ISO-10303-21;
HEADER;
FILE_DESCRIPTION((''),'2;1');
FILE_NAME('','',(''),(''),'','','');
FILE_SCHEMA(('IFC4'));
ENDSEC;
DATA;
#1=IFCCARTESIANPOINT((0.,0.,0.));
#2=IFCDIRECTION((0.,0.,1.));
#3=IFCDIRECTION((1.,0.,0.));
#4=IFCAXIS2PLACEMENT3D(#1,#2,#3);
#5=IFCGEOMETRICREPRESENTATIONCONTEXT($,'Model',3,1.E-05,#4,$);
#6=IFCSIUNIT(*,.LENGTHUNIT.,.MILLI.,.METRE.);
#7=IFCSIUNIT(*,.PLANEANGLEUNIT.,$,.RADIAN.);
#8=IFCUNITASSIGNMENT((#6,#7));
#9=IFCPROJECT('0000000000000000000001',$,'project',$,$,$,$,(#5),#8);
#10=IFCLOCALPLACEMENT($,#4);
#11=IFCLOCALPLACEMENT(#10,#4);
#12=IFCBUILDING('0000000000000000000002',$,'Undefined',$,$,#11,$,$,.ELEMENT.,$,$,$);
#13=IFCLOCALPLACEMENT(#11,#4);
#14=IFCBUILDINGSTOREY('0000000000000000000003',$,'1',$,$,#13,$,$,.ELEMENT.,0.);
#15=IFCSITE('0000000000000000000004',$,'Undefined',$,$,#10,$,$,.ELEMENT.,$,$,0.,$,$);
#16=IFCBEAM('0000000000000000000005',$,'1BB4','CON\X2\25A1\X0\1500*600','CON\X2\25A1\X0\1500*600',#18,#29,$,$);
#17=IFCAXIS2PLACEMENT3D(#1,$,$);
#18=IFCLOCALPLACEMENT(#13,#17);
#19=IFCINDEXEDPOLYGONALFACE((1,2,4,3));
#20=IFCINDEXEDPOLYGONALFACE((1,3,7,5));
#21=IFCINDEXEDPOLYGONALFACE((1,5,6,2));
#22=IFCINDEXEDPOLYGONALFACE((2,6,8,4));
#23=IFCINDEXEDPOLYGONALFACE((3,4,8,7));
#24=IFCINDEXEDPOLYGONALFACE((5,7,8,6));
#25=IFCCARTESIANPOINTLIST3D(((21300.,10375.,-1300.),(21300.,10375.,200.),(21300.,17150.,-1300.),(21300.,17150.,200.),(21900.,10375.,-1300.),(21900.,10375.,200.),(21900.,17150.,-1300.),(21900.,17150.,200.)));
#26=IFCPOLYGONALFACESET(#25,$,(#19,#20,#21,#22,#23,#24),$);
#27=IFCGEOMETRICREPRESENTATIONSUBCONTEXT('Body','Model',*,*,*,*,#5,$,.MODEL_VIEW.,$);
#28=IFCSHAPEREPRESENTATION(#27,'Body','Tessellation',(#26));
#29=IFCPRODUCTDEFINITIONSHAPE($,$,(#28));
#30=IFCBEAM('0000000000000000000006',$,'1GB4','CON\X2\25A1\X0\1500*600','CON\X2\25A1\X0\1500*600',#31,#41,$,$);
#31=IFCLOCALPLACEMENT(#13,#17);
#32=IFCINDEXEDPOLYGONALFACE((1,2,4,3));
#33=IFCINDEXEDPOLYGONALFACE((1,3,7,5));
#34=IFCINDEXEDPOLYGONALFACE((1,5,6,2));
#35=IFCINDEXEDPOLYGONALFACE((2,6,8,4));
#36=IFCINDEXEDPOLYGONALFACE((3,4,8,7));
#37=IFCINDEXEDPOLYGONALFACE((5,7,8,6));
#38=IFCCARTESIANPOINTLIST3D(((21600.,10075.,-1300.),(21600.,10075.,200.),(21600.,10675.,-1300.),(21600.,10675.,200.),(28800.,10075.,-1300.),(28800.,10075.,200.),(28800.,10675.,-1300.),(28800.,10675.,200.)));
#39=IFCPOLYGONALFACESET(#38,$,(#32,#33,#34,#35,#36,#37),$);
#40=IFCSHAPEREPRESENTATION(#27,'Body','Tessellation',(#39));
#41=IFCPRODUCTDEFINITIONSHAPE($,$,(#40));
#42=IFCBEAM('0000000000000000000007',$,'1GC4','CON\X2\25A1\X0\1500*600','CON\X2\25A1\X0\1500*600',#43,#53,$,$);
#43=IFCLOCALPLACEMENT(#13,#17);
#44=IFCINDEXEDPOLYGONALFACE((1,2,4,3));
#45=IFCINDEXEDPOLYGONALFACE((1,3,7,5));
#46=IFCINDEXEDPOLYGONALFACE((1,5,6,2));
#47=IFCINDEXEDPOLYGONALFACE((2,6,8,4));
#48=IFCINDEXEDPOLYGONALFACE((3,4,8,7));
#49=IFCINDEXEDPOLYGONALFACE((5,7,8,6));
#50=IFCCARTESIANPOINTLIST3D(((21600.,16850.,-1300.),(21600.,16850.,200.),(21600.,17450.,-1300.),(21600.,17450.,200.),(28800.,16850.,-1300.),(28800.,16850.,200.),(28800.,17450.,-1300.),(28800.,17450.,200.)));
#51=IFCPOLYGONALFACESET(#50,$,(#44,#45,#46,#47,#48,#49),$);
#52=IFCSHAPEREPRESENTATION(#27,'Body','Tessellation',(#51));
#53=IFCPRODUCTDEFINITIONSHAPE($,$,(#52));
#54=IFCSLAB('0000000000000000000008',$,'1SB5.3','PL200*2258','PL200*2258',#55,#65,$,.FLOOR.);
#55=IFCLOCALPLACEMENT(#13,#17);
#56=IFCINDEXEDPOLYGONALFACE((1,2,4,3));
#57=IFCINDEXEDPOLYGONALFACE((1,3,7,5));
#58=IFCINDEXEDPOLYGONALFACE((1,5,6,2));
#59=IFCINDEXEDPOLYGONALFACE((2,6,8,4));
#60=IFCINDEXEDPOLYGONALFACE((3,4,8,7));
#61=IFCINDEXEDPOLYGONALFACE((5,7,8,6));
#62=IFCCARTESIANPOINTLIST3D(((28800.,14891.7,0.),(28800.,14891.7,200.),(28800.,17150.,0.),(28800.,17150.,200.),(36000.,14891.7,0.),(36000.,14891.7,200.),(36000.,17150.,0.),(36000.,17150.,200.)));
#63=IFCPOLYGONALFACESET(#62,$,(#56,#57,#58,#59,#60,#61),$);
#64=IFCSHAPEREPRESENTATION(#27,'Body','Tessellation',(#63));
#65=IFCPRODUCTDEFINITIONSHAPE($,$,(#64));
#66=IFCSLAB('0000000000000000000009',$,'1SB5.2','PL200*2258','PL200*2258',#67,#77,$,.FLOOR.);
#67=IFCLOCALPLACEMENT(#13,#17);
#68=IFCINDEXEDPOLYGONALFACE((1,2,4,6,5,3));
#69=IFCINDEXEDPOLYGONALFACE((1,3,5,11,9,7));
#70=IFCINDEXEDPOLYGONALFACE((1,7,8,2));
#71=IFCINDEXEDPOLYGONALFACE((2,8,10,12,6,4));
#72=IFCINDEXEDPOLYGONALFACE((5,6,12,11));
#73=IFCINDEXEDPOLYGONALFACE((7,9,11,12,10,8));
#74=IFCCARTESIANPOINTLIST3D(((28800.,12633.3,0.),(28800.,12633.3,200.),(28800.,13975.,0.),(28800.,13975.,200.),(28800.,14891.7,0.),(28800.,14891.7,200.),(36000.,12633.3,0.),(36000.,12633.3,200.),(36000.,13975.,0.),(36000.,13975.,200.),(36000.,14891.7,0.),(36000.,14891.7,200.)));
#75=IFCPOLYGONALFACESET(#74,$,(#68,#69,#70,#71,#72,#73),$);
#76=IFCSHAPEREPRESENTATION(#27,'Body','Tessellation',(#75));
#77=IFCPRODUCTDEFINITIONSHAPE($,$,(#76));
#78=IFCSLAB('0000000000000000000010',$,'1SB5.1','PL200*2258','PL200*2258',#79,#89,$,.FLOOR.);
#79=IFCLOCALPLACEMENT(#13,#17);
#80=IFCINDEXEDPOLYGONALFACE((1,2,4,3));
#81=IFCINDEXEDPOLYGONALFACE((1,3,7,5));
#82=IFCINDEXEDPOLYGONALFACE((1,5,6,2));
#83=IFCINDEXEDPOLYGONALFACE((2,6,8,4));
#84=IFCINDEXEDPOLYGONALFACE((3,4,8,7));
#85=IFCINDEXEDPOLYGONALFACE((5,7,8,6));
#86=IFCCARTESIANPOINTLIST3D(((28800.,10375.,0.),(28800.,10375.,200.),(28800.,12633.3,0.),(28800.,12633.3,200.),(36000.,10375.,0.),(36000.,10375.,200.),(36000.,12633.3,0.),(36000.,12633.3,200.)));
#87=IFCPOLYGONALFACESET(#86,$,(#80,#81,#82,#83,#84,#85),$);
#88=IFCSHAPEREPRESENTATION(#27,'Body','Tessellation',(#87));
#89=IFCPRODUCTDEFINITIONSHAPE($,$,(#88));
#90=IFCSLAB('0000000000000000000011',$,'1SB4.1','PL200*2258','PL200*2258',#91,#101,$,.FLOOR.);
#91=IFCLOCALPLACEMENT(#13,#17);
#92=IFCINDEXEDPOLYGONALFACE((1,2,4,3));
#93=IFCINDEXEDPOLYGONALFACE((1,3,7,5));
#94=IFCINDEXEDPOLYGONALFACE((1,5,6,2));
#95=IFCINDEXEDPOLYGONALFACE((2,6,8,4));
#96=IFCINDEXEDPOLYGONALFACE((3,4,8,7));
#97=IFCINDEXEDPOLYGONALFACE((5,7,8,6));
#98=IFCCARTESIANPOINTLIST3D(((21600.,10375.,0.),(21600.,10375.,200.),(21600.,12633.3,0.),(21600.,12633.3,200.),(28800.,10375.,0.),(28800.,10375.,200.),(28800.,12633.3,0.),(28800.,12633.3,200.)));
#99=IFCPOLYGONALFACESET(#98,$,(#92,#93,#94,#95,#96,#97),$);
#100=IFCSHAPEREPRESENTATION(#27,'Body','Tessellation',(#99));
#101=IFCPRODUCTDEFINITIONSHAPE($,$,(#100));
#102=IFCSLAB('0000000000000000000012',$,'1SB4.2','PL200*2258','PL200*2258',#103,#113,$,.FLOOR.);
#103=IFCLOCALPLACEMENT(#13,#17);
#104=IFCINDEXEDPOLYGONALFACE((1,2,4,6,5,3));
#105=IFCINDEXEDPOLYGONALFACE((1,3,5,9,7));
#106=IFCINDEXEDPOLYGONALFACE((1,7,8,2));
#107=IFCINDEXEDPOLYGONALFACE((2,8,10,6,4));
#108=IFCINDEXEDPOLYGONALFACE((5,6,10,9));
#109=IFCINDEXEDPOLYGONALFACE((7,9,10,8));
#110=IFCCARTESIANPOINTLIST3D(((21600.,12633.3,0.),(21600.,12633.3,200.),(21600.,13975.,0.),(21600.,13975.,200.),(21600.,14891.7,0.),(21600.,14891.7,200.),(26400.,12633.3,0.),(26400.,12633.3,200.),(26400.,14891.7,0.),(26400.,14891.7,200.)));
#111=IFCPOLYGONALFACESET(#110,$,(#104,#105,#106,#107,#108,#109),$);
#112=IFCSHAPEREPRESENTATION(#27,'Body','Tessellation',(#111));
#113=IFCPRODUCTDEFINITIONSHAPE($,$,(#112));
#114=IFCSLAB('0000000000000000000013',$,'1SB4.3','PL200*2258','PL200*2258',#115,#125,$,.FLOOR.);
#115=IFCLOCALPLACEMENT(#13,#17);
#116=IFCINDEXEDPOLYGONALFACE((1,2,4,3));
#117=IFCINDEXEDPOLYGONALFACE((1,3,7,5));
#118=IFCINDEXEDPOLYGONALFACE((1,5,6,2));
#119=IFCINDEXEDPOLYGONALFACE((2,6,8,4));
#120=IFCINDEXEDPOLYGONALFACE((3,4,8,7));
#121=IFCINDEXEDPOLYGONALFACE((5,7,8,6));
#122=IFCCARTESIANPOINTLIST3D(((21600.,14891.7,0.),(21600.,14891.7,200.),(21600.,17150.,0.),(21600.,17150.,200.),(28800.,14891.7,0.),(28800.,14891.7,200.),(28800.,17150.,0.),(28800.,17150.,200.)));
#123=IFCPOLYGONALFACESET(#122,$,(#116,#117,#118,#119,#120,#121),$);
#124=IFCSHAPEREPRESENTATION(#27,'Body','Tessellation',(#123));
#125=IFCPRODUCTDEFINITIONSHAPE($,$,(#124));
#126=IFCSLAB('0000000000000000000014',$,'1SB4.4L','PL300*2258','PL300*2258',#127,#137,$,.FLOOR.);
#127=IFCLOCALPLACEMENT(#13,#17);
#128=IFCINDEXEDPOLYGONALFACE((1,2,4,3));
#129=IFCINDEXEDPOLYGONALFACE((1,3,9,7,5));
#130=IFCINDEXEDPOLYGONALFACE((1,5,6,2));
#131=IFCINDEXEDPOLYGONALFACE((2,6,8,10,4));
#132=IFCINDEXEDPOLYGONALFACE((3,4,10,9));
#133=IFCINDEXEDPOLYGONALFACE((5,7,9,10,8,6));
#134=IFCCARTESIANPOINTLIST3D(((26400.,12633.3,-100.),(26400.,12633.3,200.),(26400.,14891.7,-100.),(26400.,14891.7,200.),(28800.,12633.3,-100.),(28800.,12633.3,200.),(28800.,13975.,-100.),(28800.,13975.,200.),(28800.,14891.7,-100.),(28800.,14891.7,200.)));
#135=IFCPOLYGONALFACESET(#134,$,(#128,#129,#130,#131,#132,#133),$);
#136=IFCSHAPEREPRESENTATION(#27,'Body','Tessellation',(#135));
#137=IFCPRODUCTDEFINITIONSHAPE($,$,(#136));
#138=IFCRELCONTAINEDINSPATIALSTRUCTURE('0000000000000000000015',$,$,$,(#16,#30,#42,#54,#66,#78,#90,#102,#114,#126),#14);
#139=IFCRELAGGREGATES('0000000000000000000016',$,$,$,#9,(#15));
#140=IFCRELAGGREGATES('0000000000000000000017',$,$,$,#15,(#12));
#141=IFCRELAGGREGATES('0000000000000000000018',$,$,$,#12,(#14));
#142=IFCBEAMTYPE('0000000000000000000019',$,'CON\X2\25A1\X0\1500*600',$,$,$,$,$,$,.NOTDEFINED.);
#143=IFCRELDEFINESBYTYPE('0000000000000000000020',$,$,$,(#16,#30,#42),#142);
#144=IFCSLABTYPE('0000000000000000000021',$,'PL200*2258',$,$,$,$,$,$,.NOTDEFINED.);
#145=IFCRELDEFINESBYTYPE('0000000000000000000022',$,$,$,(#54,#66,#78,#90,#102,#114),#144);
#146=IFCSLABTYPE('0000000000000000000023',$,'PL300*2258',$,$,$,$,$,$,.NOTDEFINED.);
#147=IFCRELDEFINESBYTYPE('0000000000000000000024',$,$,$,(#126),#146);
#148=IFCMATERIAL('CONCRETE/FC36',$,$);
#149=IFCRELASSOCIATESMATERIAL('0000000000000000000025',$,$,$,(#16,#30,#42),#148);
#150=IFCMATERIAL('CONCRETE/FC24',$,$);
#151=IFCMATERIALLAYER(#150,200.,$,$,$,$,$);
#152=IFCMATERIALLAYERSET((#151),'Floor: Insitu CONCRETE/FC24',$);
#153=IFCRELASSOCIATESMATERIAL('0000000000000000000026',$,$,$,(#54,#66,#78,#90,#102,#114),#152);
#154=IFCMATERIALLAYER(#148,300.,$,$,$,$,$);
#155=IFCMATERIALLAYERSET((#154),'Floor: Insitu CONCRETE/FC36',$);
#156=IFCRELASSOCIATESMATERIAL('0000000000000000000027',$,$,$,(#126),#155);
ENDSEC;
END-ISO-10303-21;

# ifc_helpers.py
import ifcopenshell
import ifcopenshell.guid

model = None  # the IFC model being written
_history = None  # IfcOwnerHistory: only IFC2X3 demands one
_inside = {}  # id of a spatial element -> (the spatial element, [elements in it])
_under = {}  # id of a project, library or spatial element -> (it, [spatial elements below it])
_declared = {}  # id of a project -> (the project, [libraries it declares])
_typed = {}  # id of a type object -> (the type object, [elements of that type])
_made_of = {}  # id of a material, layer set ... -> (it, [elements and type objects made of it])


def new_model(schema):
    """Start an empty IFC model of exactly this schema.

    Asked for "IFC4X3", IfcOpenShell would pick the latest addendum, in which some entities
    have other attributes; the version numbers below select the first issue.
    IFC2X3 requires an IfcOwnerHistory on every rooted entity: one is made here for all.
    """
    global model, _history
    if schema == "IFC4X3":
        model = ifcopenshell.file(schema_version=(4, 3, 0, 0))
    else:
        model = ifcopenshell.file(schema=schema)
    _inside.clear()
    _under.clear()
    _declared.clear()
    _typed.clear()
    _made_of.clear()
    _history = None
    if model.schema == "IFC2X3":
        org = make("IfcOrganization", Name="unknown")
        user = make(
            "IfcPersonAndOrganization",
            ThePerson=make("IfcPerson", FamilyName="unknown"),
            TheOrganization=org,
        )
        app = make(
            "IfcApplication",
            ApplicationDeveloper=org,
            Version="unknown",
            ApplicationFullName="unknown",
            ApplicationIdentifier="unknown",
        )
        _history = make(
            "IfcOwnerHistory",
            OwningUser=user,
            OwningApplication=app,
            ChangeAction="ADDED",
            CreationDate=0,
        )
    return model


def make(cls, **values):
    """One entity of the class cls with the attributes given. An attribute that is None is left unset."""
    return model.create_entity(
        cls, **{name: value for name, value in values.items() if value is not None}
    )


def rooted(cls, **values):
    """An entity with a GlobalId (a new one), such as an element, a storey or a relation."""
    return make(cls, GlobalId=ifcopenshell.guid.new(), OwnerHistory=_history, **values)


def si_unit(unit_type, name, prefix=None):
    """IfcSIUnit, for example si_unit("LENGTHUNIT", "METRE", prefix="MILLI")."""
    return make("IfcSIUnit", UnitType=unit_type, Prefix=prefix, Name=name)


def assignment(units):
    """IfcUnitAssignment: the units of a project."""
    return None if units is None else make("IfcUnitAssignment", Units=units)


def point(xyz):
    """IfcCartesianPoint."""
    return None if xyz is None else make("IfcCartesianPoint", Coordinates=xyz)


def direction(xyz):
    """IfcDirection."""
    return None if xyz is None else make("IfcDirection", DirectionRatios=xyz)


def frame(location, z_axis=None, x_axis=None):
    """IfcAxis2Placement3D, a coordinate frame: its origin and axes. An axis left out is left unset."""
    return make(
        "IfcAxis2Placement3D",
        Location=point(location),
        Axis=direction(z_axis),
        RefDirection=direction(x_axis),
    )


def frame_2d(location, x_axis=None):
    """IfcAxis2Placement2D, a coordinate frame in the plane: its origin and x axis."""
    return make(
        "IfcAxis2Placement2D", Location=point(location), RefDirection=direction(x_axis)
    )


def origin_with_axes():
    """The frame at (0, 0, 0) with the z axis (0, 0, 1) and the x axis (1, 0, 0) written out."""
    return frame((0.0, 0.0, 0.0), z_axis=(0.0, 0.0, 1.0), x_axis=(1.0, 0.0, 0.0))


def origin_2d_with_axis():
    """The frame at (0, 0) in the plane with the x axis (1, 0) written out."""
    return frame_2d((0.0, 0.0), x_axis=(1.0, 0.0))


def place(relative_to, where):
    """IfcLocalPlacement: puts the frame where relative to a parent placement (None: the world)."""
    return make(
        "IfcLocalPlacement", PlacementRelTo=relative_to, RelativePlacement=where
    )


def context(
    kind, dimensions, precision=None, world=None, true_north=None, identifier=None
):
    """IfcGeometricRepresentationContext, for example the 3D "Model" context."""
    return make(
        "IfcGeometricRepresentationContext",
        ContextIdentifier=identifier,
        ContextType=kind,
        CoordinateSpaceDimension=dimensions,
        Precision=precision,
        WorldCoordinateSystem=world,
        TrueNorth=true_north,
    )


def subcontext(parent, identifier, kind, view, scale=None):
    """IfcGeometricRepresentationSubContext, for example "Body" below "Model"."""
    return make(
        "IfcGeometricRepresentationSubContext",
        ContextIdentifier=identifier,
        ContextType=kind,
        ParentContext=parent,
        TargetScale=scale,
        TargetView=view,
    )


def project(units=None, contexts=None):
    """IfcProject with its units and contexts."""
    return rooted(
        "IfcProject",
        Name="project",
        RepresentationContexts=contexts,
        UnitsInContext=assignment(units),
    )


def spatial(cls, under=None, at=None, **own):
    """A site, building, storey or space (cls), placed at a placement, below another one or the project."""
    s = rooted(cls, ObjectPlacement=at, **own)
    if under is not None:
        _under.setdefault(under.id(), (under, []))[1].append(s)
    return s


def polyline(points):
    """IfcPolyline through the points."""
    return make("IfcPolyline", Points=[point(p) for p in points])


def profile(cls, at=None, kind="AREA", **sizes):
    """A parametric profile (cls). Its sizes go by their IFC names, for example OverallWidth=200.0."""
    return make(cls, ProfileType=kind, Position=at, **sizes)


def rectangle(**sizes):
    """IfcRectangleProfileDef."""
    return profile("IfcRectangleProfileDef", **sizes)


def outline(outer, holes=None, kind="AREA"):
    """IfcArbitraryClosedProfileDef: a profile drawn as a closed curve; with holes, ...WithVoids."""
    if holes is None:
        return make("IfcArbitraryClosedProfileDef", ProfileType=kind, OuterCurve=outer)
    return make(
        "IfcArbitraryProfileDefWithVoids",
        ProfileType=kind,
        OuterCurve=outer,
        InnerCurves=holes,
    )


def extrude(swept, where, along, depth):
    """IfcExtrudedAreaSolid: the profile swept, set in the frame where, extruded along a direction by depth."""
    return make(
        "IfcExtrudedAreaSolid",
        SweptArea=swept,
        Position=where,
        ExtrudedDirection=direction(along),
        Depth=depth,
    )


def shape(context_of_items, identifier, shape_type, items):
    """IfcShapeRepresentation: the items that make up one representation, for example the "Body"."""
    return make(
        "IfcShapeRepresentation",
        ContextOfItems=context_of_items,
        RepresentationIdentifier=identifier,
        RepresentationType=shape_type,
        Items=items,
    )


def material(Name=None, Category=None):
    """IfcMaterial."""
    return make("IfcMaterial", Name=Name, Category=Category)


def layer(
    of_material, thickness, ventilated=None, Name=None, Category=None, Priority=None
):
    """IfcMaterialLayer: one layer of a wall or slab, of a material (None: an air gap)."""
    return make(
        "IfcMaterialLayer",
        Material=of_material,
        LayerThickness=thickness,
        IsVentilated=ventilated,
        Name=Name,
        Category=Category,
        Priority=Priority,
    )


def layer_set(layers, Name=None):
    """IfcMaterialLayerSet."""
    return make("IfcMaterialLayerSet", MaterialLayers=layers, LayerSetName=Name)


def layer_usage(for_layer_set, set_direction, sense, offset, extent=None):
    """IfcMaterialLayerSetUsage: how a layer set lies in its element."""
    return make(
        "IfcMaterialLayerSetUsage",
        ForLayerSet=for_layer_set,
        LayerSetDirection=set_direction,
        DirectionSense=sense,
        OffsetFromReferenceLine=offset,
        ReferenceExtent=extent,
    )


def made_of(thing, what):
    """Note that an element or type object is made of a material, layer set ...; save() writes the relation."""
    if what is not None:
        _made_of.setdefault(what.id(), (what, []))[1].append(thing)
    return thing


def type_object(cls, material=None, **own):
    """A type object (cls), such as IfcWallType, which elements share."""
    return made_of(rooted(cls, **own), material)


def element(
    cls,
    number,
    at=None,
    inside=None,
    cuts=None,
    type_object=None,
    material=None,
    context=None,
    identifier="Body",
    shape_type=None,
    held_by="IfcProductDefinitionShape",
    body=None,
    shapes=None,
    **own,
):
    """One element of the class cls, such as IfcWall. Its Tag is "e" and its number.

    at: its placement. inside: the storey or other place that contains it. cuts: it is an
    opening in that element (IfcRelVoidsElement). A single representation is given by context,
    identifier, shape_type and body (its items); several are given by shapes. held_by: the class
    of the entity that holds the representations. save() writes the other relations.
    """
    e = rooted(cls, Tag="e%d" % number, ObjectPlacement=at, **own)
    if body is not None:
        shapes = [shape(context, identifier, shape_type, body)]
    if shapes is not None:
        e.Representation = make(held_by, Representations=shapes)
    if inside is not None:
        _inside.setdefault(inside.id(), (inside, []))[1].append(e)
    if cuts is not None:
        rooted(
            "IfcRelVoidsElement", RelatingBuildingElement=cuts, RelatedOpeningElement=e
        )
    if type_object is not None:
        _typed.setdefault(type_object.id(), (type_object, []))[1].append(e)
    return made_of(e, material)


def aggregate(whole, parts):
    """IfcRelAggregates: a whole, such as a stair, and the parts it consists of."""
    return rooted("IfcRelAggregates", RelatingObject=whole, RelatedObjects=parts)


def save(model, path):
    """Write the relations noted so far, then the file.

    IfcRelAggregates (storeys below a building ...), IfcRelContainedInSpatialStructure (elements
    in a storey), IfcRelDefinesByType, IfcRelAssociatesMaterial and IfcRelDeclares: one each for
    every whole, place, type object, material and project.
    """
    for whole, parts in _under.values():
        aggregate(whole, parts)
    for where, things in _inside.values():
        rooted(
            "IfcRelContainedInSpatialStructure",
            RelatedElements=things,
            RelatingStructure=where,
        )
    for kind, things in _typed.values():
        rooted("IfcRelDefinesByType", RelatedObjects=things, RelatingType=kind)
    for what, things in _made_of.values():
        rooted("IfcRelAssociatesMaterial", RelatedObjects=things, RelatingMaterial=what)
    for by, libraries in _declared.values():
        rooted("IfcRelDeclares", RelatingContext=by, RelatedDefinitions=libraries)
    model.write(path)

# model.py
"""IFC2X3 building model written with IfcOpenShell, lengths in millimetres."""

from ifc_helpers import new_model, si_unit, frame, origin_with_axes, origin_2d_with_axis, place, context, subcontext, project, spatial, polyline, rectangle, outline, extrude, material, layer, layer_set, layer_usage, type_object, element, save


model = new_model("IFC2X3")

# Units and contexts
model_context = context("Model", 3, precision=1e-05, world=origin_with_axes())
body_context = subcontext(model_context, "Body", "Model", "MODEL_VIEW")
ifc_project = project(units=[si_unit("LENGTHUNIT", "METRE", prefix="MILLI"), si_unit("PLANEANGLEUNIT", "RADIAN")], contexts=[model_context])

# Site, building, storey
site_placement = place(None, origin_with_axes())
site = spatial("IfcSite", under=ifc_project, at=site_placement, Name="Undefined", CompositionType="ELEMENT", RefElevation=0.0)
building_placement = place(site_placement, origin_with_axes())
building = spatial("IfcBuilding", under=site, at=building_placement, Name="Undefined", CompositionType="ELEMENT")
storey_placement = place(building_placement, origin_with_axes())
storey = spatial("IfcBuildingStorey", under=building, at=storey_placement, Name="1", CompositionType="ELEMENT", Elevation=0.0)

# Shared definitions
ifc_material_1 = material(Name="CONCRETE/FC24")

# Beams
beam_type = type_object("IfcBeamType", Name="CON□1500*600", PredefinedType="NOTDEFINED")
ifc_material_2 = material(Name="CONCRETE/FC36")
beam_1_placement = place(storey_placement, frame((21600.0, 10375.0, -550.0), z_axis=(0.0, 0.0, 1.0), x_axis=(0.0, 1.0, 0.0)))
element("IfcBeam", 1, at=beam_1_placement, inside=storey, type_object=beam_type, material=ifc_material_2, Name="1BB4", Description="CON□1500*600", ObjectType="CON□1500*600", context=body_context, shape_type="SweptSolid", body=[
    extrude(rectangle(XDim=600.0, YDim=1500.0, at=origin_2d_with_axis()), frame((6775.0, 0.0, 0.0), z_axis=(-1.0, 0.0, 0.0), x_axis=(0.0, -1.0, 0.0)), (0.0, 0.0, 1.0), 6775.0),
])
for number, where, z_axis, x_axis, name in (
    (2, (21600.0, 10375.0, -550.0), (0.0, 0.0, 1.0), (1.0, 0.0, 0.0), "1GB4"),
    (3, (21600.0, 17150.0, -550.0), (0.0, 0.0, 1.0), (1.0, 0.0, 0.0), "1GC4"),
):
    element("IfcBeam", number, at=place(storey_placement, frame(where, z_axis=z_axis, x_axis=x_axis)), inside=storey, type_object=beam_type, material=ifc_material_2, Name=name, Description="CON□1500*600", ObjectType="CON□1500*600", context=body_context, shape_type="SweptSolid", body=[
        extrude(rectangle(XDim=600.0, YDim=1500.0, at=origin_2d_with_axis()), frame((7200.0, 0.0, 0.0), z_axis=(-1.0, 0.0, 0.0), x_axis=(0.0, -1.0, 0.0)), (0.0, 0.0, 1.0), 7200.0),
    ])

# Slabs
ifc_layer_1 = layer(ifc_material_1, 200.0)
ifc_layer_set_1 = layer_set([ifc_layer_1], Name="Floor: Insitu CONCRETE/FC24")
ifc_layer_usage_1 = layer_usage(ifc_layer_set_1, "AXIS3", "POSITIVE", -100.0)
slab_type_1 = type_object("IfcSlabType", Name="PL200*2258", PredefinedType="NOTDEFINED")
slab_1_placement = place(storey_placement, frame((28800.0, 14891.7, 100.0), z_axis=(0.0, 0.0, 1.0), x_axis=(1.0, 0.0, 0.0)))
element("IfcSlab", 4, at=slab_1_placement, inside=storey, type_object=slab_type_1, material=ifc_layer_usage_1, Name="1SB5.3", Description="PL200*2258", ObjectType="PL200*2258", PredefinedType="FLOOR", context=body_context, shape_type="SweptSolid", body=[
    extrude(outline(polyline([(0.0, 0.0), (7200.0, 0.0), (7200.0, 2258.3), (0.0, 2258.3), (0.0, 0.0)])), frame((0.0, 0.0, -100.0), z_axis=(0.0, 0.0, 1.0), x_axis=(1.0, 0.0, 0.0)), (0.0, 0.0, 1.0), 200.0),
])
ifc_layer_usage_2 = layer_usage(ifc_layer_set_1, "AXIS3", "POSITIVE", -100.0)
slab_2_placement = place(storey_placement, frame((28800.0, 12633.3, 100.0), z_axis=(0.0, 0.0, 1.0), x_axis=(1.0, 0.0, 0.0)))
element("IfcSlab", 5, at=slab_2_placement, inside=storey, type_object=slab_type_1, material=ifc_layer_usage_2, Name="1SB5.2", Description="PL200*2258", ObjectType="PL200*2258", PredefinedType="FLOOR", context=body_context, shape_type="SweptSolid", body=[
    extrude(outline(polyline([(0.0, 0.0), (7200.0, 0.0), (7200.0, 1341.7), (7200.0, 2258.4), (0.0, 2258.4), (0.0, 1341.7), (0.0, 0.0)])), frame((0.0, 0.0, -100.0), z_axis=(0.0, 0.0, 1.0), x_axis=(1.0, 0.0, 0.0)), (0.0, 0.0, 1.0), 200.0),
])
ifc_layer_usage_3 = layer_usage(ifc_layer_set_1, "AXIS3", "POSITIVE", -100.0)
slab_3_placement = place(storey_placement, frame((28800.0, 10375.0, 100.0), z_axis=(0.0, 0.0, 1.0), x_axis=(1.0, 0.0, 0.0)))
element("IfcSlab", 6, at=slab_3_placement, inside=storey, type_object=slab_type_1, material=ifc_layer_usage_3, Name="1SB5.1", Description="PL200*2258", ObjectType="PL200*2258", PredefinedType="FLOOR", context=body_context, shape_type="SweptSolid", body=[
    extrude(outline(polyline([(0.0, 0.0), (7200.0, 0.0), (7200.0, 2258.3), (0.0, 2258.3), (0.0, 0.0)])), frame((0.0, 0.0, -100.0), z_axis=(0.0, 0.0, 1.0), x_axis=(1.0, 0.0, 0.0)), (0.0, 0.0, 1.0), 200.0),
])
ifc_layer_usage_4 = layer_usage(ifc_layer_set_1, "AXIS3", "POSITIVE", -100.0)
slab_4_placement = place(storey_placement, frame((21600.0, 10375.0, 100.0), z_axis=(0.0, 0.0, 1.0), x_axis=(1.0, 0.0, 0.0)))
element("IfcSlab", 7, at=slab_4_placement, inside=storey, type_object=slab_type_1, material=ifc_layer_usage_4, Name="1SB4.1", Description="PL200*2258", ObjectType="PL200*2258", PredefinedType="FLOOR", context=body_context, shape_type="SweptSolid", body=[
    extrude(outline(polyline([(0.0, 0.0), (7200.0, 0.0), (7200.0, 2258.3), (0.0, 2258.3), (0.0, 0.0)])), frame((0.0, 0.0, -100.0), z_axis=(0.0, 0.0, 1.0), x_axis=(1.0, 0.0, 0.0)), (0.0, 0.0, 1.0), 200.0),
])
ifc_layer_usage_5 = layer_usage(ifc_layer_set_1, "AXIS3", "POSITIVE", -100.0)
slab_5_placement = place(storey_placement, frame((21600.0, 12633.3, 100.0), z_axis=(0.0, 0.0, 1.0), x_axis=(1.0, 0.0, 0.0)))
element("IfcSlab", 8, at=slab_5_placement, inside=storey, type_object=slab_type_1, material=ifc_layer_usage_5, Name="1SB4.2", Description="PL200*2258", ObjectType="PL200*2258", PredefinedType="FLOOR", context=body_context, shape_type="SweptSolid", body=[
    extrude(outline(polyline([(0.0, 0.0), (4800.0, 0.0), (4800.0, 2258.4), (0.0, 2258.4), (0.0, 1341.7), (0.0, 0.0)])), frame((0.0, 0.0, -100.0), z_axis=(0.0, 0.0, 1.0), x_axis=(1.0, 0.0, 0.0)), (0.0, 0.0, 1.0), 200.0),
])
ifc_layer_usage_6 = layer_usage(ifc_layer_set_1, "AXIS3", "POSITIVE", -100.0)
slab_6_placement = place(storey_placement, frame((21600.0, 14891.7, 100.0), z_axis=(0.0, 0.0, 1.0), x_axis=(1.0, 0.0, 0.0)))
element("IfcSlab", 9, at=slab_6_placement, inside=storey, type_object=slab_type_1, material=ifc_layer_usage_6, Name="1SB4.3", Description="PL200*2258", ObjectType="PL200*2258", PredefinedType="FLOOR", context=body_context, shape_type="SweptSolid", body=[
    extrude(outline(polyline([(0.0, 0.0), (7200.0, 0.0), (7200.0, 2258.3), (0.0, 2258.3), (0.0, 0.0)])), frame((0.0, 0.0, -100.0), z_axis=(0.0, 0.0, 1.0), x_axis=(1.0, 0.0, 0.0)), (0.0, 0.0, 1.0), 200.0),
])
ifc_layer_2 = layer(ifc_material_2, 300.0)
ifc_layer_set_2 = layer_set([ifc_layer_2], Name="Floor: Insitu CONCRETE/FC36")
ifc_layer_usage_7 = layer_usage(ifc_layer_set_2, "AXIS3", "POSITIVE", -150.0)
slab_type_2 = type_object("IfcSlabType", Name="PL300*2258", PredefinedType="NOTDEFINED")
slab_7_placement = place(storey_placement, frame((26400.0, 12633.3, 50.0), z_axis=(0.0, 0.0, 1.0), x_axis=(1.0, 0.0, 0.0)))
element("IfcSlab", 10, at=slab_7_placement, inside=storey, type_object=slab_type_2, material=ifc_layer_usage_7, Name="1SB4.4L", Description="PL300*2258", ObjectType="PL300*2258", PredefinedType="FLOOR", context=body_context, shape_type="SweptSolid", body=[
    extrude(outline(polyline([(0.0, 0.0), (2400.0, 0.0), (2400.0, 1341.7), (2400.0, 2258.4), (0.0, 2258.4), (0.0, 0.0)])), frame((0.0, 0.0, -150.0), z_axis=(0.0, 0.0, 1.0), x_axis=(1.0, 0.0, 0.0)), (0.0, 0.0, 1.0), 300.0),
])

save(model, "model.ifc")
